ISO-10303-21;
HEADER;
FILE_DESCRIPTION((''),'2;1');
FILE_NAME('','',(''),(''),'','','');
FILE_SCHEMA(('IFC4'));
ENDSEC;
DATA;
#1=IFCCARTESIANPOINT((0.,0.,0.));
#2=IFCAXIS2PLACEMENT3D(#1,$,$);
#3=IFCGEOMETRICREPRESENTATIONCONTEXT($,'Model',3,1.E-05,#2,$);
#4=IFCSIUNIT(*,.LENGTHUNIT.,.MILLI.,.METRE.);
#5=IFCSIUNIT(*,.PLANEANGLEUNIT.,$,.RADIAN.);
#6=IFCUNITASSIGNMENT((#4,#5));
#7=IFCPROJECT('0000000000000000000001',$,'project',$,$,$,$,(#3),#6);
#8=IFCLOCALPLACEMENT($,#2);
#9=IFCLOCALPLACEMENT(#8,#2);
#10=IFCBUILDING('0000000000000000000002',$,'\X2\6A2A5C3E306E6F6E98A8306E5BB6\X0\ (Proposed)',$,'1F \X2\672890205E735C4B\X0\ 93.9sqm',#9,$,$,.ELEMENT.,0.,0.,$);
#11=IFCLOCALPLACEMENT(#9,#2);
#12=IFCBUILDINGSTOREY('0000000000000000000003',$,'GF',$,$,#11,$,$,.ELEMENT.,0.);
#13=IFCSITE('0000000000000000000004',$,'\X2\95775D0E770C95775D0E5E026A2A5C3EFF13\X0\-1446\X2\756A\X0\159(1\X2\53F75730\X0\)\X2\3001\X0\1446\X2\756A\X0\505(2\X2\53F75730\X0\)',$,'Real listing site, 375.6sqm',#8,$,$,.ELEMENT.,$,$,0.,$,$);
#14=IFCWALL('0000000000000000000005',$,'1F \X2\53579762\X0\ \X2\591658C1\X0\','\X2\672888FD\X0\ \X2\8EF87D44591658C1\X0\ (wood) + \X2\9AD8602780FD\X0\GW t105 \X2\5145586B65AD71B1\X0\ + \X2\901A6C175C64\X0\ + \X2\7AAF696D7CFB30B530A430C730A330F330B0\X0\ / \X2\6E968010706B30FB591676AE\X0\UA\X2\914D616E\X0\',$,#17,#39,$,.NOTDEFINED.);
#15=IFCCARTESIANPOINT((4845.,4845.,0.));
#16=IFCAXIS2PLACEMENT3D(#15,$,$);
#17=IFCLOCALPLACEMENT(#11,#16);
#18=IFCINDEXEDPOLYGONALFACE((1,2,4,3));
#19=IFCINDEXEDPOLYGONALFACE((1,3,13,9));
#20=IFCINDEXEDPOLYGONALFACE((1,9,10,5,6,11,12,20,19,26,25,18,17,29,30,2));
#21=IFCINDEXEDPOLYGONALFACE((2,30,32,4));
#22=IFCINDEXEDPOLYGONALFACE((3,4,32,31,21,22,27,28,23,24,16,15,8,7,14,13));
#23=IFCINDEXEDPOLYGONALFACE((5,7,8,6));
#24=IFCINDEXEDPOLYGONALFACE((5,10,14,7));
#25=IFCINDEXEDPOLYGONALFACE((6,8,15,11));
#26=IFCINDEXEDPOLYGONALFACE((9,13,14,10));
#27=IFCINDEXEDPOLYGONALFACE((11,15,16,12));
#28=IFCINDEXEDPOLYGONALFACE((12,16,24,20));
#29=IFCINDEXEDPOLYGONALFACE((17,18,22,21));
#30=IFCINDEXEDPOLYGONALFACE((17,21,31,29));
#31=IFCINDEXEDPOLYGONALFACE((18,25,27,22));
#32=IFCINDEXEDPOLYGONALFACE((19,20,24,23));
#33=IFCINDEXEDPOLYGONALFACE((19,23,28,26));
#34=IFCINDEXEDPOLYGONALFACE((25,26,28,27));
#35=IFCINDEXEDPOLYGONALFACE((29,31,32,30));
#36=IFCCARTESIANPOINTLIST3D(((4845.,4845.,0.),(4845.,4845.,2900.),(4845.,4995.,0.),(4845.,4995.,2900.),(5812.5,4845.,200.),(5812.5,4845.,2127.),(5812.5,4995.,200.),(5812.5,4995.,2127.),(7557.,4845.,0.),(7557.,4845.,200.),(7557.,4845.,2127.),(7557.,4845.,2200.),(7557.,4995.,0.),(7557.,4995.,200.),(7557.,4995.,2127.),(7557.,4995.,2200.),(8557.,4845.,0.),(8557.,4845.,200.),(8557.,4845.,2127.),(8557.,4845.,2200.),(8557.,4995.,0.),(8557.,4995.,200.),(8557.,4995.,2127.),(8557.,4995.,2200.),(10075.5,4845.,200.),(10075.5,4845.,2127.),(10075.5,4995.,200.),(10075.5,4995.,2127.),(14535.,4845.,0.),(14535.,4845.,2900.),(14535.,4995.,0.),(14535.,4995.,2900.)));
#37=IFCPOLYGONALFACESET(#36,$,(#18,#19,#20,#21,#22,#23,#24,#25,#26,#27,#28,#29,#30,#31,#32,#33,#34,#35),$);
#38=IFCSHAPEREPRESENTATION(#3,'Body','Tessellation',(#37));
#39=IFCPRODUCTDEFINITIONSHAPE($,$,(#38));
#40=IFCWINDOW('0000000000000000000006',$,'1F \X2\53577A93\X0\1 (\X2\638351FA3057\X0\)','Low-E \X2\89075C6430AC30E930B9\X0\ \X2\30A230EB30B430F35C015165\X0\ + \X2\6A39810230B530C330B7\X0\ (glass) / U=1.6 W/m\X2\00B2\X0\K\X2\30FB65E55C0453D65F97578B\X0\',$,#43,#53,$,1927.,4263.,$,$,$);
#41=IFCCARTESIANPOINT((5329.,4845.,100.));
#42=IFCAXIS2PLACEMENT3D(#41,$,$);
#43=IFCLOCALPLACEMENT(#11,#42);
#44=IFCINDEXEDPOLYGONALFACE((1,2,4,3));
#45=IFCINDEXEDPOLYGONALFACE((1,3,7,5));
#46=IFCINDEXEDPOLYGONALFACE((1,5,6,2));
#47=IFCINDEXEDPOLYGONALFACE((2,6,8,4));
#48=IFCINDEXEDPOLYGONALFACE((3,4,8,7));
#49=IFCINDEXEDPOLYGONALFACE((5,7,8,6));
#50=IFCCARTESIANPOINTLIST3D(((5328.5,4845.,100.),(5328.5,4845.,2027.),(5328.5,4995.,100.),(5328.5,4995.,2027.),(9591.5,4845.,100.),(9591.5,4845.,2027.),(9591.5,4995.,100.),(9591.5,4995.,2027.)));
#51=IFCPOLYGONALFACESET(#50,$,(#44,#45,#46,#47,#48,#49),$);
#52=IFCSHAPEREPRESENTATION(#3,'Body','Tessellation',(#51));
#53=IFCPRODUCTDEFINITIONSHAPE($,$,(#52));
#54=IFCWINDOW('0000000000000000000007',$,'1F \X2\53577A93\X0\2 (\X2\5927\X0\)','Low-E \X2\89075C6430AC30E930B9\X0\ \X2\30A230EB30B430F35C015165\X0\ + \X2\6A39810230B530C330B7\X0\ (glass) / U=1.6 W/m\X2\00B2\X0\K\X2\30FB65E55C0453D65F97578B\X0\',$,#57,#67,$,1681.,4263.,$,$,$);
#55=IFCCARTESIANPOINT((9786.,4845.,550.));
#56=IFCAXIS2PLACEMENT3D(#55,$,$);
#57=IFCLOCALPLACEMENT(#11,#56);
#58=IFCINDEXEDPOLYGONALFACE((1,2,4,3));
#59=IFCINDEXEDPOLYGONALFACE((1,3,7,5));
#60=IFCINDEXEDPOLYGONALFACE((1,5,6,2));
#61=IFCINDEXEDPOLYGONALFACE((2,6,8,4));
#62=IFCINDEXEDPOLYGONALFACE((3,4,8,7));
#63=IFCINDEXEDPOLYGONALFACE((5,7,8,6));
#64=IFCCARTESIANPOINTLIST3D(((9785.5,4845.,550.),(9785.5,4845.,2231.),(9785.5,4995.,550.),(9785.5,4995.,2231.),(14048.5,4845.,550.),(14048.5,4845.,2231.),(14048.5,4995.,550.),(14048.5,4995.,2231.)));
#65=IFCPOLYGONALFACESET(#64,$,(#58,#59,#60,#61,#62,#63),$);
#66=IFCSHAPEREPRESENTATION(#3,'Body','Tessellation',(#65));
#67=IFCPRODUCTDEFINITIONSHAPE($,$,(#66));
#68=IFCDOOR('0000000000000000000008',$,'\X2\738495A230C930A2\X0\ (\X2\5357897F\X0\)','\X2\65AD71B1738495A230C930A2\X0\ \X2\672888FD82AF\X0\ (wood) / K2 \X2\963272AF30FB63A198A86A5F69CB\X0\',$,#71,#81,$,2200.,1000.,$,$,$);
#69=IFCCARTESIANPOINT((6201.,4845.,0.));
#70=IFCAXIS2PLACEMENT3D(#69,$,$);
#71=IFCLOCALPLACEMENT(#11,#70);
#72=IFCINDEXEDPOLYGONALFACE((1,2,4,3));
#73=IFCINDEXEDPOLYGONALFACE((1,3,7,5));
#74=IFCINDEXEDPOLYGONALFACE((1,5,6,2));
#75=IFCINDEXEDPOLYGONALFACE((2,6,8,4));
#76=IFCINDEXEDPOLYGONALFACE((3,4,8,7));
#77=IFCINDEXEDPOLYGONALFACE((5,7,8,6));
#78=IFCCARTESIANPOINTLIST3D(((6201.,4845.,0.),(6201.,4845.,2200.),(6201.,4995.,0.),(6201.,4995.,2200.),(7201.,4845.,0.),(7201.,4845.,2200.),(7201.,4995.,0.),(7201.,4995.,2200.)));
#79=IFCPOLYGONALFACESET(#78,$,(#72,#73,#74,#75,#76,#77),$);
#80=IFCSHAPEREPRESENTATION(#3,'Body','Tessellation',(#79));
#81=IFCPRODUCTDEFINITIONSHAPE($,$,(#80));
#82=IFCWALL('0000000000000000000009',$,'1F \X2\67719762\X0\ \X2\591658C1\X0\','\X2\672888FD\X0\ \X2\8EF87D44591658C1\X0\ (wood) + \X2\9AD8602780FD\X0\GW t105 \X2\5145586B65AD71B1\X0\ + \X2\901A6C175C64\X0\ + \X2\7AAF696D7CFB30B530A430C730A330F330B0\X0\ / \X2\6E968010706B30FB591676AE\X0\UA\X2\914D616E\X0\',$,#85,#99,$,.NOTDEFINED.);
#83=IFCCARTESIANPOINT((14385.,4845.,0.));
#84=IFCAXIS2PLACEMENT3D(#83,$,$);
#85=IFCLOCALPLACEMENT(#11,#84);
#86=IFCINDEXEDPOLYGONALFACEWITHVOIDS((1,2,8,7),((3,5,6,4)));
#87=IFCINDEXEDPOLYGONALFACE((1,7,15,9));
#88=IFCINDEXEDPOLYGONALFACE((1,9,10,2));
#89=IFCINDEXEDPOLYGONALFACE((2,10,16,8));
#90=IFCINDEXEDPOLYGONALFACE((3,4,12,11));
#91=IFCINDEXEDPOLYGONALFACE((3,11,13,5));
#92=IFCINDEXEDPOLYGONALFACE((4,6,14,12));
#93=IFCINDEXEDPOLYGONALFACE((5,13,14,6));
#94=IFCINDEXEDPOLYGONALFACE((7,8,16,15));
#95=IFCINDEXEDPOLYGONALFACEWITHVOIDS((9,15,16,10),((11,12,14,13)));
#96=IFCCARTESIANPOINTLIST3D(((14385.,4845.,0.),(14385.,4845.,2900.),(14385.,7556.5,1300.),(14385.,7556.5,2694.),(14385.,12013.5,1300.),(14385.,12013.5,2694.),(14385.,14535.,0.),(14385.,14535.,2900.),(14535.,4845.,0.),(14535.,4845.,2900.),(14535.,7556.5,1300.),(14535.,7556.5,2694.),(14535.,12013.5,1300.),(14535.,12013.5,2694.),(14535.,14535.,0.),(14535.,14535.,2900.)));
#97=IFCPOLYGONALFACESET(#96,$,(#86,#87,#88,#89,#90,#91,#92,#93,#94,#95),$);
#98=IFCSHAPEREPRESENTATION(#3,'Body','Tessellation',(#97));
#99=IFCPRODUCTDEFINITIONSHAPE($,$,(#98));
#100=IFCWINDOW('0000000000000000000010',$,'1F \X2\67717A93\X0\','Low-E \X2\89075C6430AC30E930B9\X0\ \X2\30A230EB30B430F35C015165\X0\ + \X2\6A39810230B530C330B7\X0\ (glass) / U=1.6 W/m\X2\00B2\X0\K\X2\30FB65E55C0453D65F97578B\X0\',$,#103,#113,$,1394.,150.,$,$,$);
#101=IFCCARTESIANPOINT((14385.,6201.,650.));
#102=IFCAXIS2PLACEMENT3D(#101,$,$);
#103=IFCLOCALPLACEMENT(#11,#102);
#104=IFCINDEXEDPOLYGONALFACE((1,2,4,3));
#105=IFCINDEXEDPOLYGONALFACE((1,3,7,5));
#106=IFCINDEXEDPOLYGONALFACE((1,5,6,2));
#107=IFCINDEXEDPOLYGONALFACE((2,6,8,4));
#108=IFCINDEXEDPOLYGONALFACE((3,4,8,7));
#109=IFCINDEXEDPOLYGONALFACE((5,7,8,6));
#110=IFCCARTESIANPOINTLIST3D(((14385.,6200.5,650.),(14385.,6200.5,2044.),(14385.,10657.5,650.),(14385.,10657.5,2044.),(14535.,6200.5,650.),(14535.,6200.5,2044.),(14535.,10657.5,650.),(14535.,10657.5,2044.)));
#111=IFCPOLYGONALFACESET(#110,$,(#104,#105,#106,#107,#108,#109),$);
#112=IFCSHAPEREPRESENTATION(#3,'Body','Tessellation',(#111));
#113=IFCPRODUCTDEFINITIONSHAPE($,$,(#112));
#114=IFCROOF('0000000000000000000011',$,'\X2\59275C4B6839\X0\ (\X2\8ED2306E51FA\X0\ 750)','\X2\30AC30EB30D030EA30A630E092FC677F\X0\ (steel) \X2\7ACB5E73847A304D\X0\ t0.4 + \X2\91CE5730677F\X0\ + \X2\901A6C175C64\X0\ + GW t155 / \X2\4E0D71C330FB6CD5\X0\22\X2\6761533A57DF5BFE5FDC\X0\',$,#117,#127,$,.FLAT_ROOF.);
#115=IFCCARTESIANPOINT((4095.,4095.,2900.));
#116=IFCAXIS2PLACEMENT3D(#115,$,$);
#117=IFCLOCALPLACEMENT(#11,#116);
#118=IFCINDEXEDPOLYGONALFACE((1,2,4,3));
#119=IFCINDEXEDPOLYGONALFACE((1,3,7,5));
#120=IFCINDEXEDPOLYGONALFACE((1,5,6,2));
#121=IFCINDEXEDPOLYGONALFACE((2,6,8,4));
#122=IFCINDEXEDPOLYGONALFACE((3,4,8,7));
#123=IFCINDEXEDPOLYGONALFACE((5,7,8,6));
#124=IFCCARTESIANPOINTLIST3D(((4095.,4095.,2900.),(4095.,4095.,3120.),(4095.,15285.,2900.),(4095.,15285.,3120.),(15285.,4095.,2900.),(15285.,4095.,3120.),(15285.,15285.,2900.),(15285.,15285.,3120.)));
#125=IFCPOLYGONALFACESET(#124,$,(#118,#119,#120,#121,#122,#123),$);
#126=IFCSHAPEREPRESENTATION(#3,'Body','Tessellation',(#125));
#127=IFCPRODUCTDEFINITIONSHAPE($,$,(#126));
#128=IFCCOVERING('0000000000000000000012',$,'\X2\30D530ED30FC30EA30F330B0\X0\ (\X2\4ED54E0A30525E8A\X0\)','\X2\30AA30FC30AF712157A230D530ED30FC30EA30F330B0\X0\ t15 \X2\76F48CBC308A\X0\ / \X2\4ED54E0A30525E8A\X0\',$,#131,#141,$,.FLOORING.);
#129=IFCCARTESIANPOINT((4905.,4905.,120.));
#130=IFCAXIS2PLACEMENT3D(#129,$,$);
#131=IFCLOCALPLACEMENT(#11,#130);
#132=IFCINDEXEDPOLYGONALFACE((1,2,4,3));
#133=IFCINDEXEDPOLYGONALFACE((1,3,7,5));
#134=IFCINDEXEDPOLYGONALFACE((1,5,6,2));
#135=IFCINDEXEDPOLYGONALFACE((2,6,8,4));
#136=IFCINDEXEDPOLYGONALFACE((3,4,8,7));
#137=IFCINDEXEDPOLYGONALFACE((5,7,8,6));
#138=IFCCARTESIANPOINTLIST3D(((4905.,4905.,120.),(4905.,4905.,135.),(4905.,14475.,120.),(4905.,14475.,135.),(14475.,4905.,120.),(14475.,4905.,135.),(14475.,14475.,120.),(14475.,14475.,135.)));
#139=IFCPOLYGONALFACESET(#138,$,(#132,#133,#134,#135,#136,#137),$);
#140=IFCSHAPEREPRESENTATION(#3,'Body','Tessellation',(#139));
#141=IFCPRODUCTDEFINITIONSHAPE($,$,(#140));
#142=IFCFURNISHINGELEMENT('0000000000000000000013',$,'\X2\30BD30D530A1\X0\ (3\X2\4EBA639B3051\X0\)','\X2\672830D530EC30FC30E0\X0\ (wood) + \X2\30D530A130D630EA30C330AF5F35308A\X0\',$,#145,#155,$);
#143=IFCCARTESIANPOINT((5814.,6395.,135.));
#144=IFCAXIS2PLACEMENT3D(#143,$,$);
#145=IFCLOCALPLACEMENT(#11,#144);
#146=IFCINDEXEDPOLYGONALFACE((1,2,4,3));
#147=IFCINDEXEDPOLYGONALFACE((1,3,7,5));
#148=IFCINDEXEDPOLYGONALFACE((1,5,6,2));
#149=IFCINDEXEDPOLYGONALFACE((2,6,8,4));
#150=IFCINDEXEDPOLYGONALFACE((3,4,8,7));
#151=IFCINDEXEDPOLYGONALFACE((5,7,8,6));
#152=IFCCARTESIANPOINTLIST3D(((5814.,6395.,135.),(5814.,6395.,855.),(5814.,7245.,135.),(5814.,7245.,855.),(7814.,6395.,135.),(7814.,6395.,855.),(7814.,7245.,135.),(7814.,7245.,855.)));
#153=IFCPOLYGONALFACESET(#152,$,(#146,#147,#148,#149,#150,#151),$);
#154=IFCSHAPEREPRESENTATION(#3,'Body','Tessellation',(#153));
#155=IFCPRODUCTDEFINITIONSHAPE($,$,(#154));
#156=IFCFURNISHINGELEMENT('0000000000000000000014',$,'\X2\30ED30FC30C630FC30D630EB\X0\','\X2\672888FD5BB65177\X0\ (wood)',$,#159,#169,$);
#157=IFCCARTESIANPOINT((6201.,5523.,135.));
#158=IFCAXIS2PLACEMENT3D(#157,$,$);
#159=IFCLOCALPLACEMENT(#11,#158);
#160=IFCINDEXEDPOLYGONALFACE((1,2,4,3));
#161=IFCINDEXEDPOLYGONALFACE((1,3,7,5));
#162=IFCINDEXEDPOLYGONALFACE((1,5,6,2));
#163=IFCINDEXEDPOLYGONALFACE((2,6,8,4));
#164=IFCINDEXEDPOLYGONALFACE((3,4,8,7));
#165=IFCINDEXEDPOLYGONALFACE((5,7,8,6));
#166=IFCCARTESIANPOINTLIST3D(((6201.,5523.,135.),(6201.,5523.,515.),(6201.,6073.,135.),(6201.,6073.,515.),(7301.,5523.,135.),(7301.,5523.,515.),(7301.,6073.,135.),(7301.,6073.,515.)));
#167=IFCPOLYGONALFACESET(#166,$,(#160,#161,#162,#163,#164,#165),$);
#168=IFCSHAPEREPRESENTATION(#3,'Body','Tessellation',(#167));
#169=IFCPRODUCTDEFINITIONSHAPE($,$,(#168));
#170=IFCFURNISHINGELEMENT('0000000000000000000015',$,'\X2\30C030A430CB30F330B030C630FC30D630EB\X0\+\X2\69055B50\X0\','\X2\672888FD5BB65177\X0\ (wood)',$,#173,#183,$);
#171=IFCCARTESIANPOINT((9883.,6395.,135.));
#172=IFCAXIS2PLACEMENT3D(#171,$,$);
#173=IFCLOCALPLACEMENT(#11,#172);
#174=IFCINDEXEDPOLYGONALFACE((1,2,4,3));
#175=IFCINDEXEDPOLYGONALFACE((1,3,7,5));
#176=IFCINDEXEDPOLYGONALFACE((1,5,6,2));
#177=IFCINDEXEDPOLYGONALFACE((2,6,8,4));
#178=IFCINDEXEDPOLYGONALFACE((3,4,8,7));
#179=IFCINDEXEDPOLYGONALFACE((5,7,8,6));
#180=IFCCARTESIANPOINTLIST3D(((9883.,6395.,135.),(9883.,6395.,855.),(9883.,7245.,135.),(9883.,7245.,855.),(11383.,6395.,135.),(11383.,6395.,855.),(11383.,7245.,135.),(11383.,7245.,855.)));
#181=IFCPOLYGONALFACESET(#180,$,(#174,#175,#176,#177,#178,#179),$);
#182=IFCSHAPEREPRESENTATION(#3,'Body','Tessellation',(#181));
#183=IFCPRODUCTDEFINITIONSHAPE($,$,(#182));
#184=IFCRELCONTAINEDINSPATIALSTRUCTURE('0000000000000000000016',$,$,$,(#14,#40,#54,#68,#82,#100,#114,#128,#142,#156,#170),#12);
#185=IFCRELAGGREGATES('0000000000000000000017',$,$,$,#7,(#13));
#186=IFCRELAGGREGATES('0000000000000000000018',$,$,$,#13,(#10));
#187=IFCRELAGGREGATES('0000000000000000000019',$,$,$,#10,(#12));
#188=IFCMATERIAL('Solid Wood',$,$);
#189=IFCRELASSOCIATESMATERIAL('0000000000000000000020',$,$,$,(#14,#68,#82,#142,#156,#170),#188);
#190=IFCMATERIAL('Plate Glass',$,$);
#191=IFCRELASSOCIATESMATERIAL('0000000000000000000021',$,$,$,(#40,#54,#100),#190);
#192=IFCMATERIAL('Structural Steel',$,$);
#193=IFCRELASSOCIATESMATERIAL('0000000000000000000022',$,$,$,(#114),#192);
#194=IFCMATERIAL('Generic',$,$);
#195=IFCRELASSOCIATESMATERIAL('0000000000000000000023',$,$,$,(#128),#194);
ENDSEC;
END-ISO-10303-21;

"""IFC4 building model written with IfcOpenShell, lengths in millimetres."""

from ifc_helpers import new_model, si_unit, frame, frame_2d, origin, place, context, project, spatial, rectangle, extrude, material, element, fill, save


model = new_model("IFC4")

# Units and contexts
model_context = context("Model", 3, precision=1e-05, world=origin())
ifc_project = project(units=[si_unit("LENGTHUNIT", "METRE", prefix="MILLI"), si_unit("PLANEANGLEUNIT", "RADIAN")], contexts=[model_context])

# Site, building, storey
site_placement = place(None, origin())
site = spatial("IfcSite", under=ifc_project, at=site_placement, Name="長崎県長崎市横尾３-1446番159(1号地)、1446番505(2号地)", ObjectType="Real listing site, 375.6sqm", CompositionType="ELEMENT", RefElevation=0.0)
building_placement = place(site_placement, origin())
building = spatial("IfcBuilding", under=site, at=building_placement, Name="横尾の潮風の家 (Proposed)", ObjectType="1F 木造平屋 93.9sqm", CompositionType="ELEMENT", ElevationOfRefHeight=0.0, ElevationOfTerrain=0.0)
storey_placement = place(building_placement, origin())
storey = spatial("IfcBuildingStorey", under=building, at=storey_placement, Name="GF", CompositionType="ELEMENT", Elevation=0.0)

# Shared definitions
ifc_material_1 = material(Name="Solid Wood")

# Wall, openings, windows, door
wall_1_placement = place(storey_placement, frame((4845.0, 4845.0, 0.0)))
wall_1 = element("IfcWall", 1, at=wall_1_placement, inside=storey, material=ifc_material_1, Name="1F 南面 外壁", Description="木製 軸組外壁 (wood) + 高性能GW t105 充填断熱 + 通気層 + 窯業系サイディング / 準耐火・外皮UA配慮", PredefinedType="NOTDEFINED", context=model_context, shape_type="SweptSolid", body=[
    extrude(rectangle(XDim=9690.0, YDim=150.0, at=frame_2d((4845.0, 75.0))), frame((4845.0, 4845.0, 0.0)), (0.0, 0.0, 1.0), 2900.0),
])
opening_1_placement = place(storey_placement, frame((5329.0, 4845.0, 100.0)))
opening_1 = element("IfcOpeningElement", 2, at=opening_1_placement, cuts=wall_1, PredefinedType="NOTDEFINED", context=model_context, shape_type="SweptSolid", body=[
    extrude(rectangle(XDim=4263.0, YDim=150.0, at=frame_2d((2131.0, 75.0))), frame((5329.0, 4845.0, 100.0)), (0.0, 0.0, 1.0), 1927.0),
])
opening_2_placement = place(storey_placement, frame((9786.0, 4845.0, 550.0)))
opening_2 = element("IfcOpeningElement", 3, at=opening_2_placement, cuts=wall_1, PredefinedType="NOTDEFINED", context=model_context, shape_type="SweptSolid", body=[
    extrude(rectangle(XDim=4263.0, YDim=150.0, at=frame_2d((2131.0, 75.0))), frame((9786.0, 4845.0, 550.0)), (0.0, 0.0, 1.0), 1681.0),
])
opening_3_placement = place(storey_placement, frame((6201.0, 4845.0, 0.0)))
opening_3 = element("IfcOpeningElement", 4, at=opening_3_placement, cuts=wall_1, PredefinedType="NOTDEFINED", context=model_context, shape_type="SweptSolid", body=[
    extrude(rectangle(XDim=1000.0, YDim=150.0, at=frame_2d((500.0, 75.0))), frame((6201.0, 4845.0, 0.0)), (0.0, 0.0, 1.0), 2200.0),
])
ifc_material_2 = material(Name="Plate Glass")
window_1_placement = place(storey_placement, frame((5329.0, 4845.0, 100.0)))
window_1 = element("IfcWindow", 5, at=window_1_placement, inside=storey, material=ifc_material_2, Name="1F 南窓1 (掃出し)", Description="Low-E 複層ガラス アルゴン封入 + 樹脂サッシ (glass) / U=1.6 W/m²K・日射取得型", OverallHeight=1927.0, OverallWidth=4263.0, context=model_context, shape_type="SweptSolid", body=[
    extrude(rectangle(XDim=4263.0, YDim=150.0, at=frame_2d((2131.0, 75.0))), frame((5329.0, 4845.0, 100.0)), (0.0, 0.0, 1.0), 1927.0),
])
fill(opening_1, window_1)
window_2_placement = place(storey_placement, frame((9786.0, 4845.0, 550.0)))
window_2 = element("IfcWindow", 6, at=window_2_placement, inside=storey, material=ifc_material_2, Name="1F 南窓2 (大)", Description="Low-E 複層ガラス アルゴン封入 + 樹脂サッシ (glass) / U=1.6 W/m²K・日射取得型", OverallHeight=1681.0, OverallWidth=4263.0, context=model_context, shape_type="SweptSolid", body=[
    extrude(rectangle(XDim=4263.0, YDim=150.0, at=frame_2d((2131.0, 75.0))), frame((9786.0, 4845.0, 550.0)), (0.0, 0.0, 1.0), 1681.0),
])
fill(opening_2, window_2)
door_placement = place(storey_placement, frame((6201.0, 4845.0, 0.0)))
door = element("IfcDoor", 7, at=door_placement, inside=storey, material=ifc_material_1, Name="玄関ドア (南西)", Description="断熱玄関ドア 木製芯 (wood) / K2 防犯・採風機構", OverallHeight=2200.0, OverallWidth=1000.0, context=model_context, shape_type="SweptSolid", body=[
    extrude(rectangle(XDim=1000.0, YDim=150.0, at=frame_2d((500.0, 75.0))), frame((6201.0, 4845.0, 0.0)), (0.0, 0.0, 1.0), 2200.0),
])
fill(opening_3, door)

# Wall, opening, window
wall_2_placement = place(storey_placement, frame((14385.0, 4845.0, 0.0)))
wall_2 = element("IfcWall", 8, at=wall_2_placement, inside=storey, material=ifc_material_1, Name="1F 東面 外壁", Description="木製 軸組外壁 (wood) + 高性能GW t105 充填断熱 + 通気層 + 窯業系サイディング / 準耐火・外皮UA配慮", PredefinedType="NOTDEFINED", context=model_context, shape_type="SweptSolid", body=[
    extrude(rectangle(XDim=150.0, YDim=9690.0, at=frame_2d((75.0, 4845.0))), frame((14385.0, 4845.0, 0.0)), (0.0, 0.0, 1.0), 2900.0),
])
opening_4_placement = place(storey_placement, frame((14385.0, 6201.0, 650.0)))
opening_4 = element("IfcOpeningElement", 9, at=opening_4_placement, cuts=wall_2, PredefinedType="NOTDEFINED", context=model_context, shape_type="SweptSolid", body=[
    extrude(rectangle(XDim=150.0, YDim=4457.0, at=frame_2d((75.0, 2228.0))), frame((14385.0, 6201.0, 650.0)), (0.0, 0.0, 1.0), 1394.0),
])
window_3_placement = place(storey_placement, frame((14385.0, 6201.0, 650.0)))
window_3 = element("IfcWindow", 10, at=window_3_placement, inside=storey, material=ifc_material_2, Name="1F 東窓", Description="Low-E 複層ガラス アルゴン封入 + 樹脂サッシ (glass) / U=1.6 W/m²K・日射取得型", OverallHeight=1394.0, OverallWidth=150.0, context=model_context, shape_type="SweptSolid", body=[
    extrude(rectangle(XDim=150.0, YDim=4457.0, at=frame_2d((75.0, 2228.0))), frame((14385.0, 6201.0, 650.0)), (0.0, 0.0, 1.0), 1394.0),
])
fill(opening_4, window_3)

# Roof
ifc_material_3 = material(Name="Structural Steel")
roof_placement = place(storey_placement, frame((4095.0, 4095.0, 2900.0)))
element("IfcRoof", 11, at=roof_placement, inside=storey, material=ifc_material_3, Name="大屋根 (軒の出 750)", Description="ガルバリウム鋼板 (steel) 立平葺き t0.4 + 野地板 + 通気層 + GW t155 / 不燃・法22条区域対応", PredefinedType="FLAT_ROOF", context=model_context, shape_type="SweptSolid", body=[
    extrude(rectangle(XDim=11190.0, YDim=11190.0, at=frame_2d((5595.0, 5595.0))), frame((4095.0, 4095.0, 2900.0)), (0.0, 0.0, 1.0), 220.0),
])

# Covering
ifc_material_4 = material(Name="Generic")
covering_placement = place(storey_placement, frame((4905.0, 4905.0, 120.0)))
element("IfcCovering", 12, at=covering_placement, inside=storey, material=ifc_material_4, Name="フローリング (仕上げ床)", Description="オーク無垢フローリング t15 直貼り / 仕上げ床", PredefinedType="FLOORING", context=model_context, shape_type="SweptSolid", body=[
    extrude(rectangle(XDim=9570.0, YDim=9570.0, at=frame_2d((4785.0, 4785.0))), frame((4905.0, 4905.0, 120.0)), (0.0, 0.0, 1.0), 15.0),
])

# Furnishing elements
furnishing_1_placement = place(storey_placement, frame((5814.0, 6395.0, 135.0)))
element("IfcFurnishingElement", 13, at=furnishing_1_placement, inside=storey, material=ifc_material_1, Name="ソファ (3人掛け)", Description="木フレーム (wood) + ファブリック張り", context=model_context, shape_type="SweptSolid", body=[
    extrude(rectangle(XDim=2000.0, YDim=850.0, at=frame_2d((1000.0, 425.0))), frame((5814.0, 6395.0, 135.0)), (0.0, 0.0, 1.0), 720.0),
])
furnishing_2_placement = place(storey_placement, frame((6201.0, 5523.0, 135.0)))
element("IfcFurnishingElement", 14, at=furnishing_2_placement, inside=storey, material=ifc_material_1, Name="ローテーブル", Description="木製家具 (wood)", context=model_context, shape_type="SweptSolid", body=[
    extrude(rectangle(XDim=1100.0, YDim=550.0, at=frame_2d((550.0, 275.0))), frame((6201.0, 5523.0, 135.0)), (0.0, 0.0, 1.0), 380.0),
])
furnishing_3_placement = place(storey_placement, frame((9883.0, 6395.0, 135.0)))
element("IfcFurnishingElement", 15, at=furnishing_3_placement, inside=storey, material=ifc_material_1, Name="ダイニングテーブル+椅子", Description="木製家具 (wood)", context=model_context, shape_type="SweptSolid", body=[
    extrude(rectangle(XDim=1500.0, YDim=850.0, at=frame_2d((750.0, 425.0))), frame((9883.0, 6395.0, 135.0)), (0.0, 0.0, 1.0), 720.0),
])

save(model, "model.ifc")
